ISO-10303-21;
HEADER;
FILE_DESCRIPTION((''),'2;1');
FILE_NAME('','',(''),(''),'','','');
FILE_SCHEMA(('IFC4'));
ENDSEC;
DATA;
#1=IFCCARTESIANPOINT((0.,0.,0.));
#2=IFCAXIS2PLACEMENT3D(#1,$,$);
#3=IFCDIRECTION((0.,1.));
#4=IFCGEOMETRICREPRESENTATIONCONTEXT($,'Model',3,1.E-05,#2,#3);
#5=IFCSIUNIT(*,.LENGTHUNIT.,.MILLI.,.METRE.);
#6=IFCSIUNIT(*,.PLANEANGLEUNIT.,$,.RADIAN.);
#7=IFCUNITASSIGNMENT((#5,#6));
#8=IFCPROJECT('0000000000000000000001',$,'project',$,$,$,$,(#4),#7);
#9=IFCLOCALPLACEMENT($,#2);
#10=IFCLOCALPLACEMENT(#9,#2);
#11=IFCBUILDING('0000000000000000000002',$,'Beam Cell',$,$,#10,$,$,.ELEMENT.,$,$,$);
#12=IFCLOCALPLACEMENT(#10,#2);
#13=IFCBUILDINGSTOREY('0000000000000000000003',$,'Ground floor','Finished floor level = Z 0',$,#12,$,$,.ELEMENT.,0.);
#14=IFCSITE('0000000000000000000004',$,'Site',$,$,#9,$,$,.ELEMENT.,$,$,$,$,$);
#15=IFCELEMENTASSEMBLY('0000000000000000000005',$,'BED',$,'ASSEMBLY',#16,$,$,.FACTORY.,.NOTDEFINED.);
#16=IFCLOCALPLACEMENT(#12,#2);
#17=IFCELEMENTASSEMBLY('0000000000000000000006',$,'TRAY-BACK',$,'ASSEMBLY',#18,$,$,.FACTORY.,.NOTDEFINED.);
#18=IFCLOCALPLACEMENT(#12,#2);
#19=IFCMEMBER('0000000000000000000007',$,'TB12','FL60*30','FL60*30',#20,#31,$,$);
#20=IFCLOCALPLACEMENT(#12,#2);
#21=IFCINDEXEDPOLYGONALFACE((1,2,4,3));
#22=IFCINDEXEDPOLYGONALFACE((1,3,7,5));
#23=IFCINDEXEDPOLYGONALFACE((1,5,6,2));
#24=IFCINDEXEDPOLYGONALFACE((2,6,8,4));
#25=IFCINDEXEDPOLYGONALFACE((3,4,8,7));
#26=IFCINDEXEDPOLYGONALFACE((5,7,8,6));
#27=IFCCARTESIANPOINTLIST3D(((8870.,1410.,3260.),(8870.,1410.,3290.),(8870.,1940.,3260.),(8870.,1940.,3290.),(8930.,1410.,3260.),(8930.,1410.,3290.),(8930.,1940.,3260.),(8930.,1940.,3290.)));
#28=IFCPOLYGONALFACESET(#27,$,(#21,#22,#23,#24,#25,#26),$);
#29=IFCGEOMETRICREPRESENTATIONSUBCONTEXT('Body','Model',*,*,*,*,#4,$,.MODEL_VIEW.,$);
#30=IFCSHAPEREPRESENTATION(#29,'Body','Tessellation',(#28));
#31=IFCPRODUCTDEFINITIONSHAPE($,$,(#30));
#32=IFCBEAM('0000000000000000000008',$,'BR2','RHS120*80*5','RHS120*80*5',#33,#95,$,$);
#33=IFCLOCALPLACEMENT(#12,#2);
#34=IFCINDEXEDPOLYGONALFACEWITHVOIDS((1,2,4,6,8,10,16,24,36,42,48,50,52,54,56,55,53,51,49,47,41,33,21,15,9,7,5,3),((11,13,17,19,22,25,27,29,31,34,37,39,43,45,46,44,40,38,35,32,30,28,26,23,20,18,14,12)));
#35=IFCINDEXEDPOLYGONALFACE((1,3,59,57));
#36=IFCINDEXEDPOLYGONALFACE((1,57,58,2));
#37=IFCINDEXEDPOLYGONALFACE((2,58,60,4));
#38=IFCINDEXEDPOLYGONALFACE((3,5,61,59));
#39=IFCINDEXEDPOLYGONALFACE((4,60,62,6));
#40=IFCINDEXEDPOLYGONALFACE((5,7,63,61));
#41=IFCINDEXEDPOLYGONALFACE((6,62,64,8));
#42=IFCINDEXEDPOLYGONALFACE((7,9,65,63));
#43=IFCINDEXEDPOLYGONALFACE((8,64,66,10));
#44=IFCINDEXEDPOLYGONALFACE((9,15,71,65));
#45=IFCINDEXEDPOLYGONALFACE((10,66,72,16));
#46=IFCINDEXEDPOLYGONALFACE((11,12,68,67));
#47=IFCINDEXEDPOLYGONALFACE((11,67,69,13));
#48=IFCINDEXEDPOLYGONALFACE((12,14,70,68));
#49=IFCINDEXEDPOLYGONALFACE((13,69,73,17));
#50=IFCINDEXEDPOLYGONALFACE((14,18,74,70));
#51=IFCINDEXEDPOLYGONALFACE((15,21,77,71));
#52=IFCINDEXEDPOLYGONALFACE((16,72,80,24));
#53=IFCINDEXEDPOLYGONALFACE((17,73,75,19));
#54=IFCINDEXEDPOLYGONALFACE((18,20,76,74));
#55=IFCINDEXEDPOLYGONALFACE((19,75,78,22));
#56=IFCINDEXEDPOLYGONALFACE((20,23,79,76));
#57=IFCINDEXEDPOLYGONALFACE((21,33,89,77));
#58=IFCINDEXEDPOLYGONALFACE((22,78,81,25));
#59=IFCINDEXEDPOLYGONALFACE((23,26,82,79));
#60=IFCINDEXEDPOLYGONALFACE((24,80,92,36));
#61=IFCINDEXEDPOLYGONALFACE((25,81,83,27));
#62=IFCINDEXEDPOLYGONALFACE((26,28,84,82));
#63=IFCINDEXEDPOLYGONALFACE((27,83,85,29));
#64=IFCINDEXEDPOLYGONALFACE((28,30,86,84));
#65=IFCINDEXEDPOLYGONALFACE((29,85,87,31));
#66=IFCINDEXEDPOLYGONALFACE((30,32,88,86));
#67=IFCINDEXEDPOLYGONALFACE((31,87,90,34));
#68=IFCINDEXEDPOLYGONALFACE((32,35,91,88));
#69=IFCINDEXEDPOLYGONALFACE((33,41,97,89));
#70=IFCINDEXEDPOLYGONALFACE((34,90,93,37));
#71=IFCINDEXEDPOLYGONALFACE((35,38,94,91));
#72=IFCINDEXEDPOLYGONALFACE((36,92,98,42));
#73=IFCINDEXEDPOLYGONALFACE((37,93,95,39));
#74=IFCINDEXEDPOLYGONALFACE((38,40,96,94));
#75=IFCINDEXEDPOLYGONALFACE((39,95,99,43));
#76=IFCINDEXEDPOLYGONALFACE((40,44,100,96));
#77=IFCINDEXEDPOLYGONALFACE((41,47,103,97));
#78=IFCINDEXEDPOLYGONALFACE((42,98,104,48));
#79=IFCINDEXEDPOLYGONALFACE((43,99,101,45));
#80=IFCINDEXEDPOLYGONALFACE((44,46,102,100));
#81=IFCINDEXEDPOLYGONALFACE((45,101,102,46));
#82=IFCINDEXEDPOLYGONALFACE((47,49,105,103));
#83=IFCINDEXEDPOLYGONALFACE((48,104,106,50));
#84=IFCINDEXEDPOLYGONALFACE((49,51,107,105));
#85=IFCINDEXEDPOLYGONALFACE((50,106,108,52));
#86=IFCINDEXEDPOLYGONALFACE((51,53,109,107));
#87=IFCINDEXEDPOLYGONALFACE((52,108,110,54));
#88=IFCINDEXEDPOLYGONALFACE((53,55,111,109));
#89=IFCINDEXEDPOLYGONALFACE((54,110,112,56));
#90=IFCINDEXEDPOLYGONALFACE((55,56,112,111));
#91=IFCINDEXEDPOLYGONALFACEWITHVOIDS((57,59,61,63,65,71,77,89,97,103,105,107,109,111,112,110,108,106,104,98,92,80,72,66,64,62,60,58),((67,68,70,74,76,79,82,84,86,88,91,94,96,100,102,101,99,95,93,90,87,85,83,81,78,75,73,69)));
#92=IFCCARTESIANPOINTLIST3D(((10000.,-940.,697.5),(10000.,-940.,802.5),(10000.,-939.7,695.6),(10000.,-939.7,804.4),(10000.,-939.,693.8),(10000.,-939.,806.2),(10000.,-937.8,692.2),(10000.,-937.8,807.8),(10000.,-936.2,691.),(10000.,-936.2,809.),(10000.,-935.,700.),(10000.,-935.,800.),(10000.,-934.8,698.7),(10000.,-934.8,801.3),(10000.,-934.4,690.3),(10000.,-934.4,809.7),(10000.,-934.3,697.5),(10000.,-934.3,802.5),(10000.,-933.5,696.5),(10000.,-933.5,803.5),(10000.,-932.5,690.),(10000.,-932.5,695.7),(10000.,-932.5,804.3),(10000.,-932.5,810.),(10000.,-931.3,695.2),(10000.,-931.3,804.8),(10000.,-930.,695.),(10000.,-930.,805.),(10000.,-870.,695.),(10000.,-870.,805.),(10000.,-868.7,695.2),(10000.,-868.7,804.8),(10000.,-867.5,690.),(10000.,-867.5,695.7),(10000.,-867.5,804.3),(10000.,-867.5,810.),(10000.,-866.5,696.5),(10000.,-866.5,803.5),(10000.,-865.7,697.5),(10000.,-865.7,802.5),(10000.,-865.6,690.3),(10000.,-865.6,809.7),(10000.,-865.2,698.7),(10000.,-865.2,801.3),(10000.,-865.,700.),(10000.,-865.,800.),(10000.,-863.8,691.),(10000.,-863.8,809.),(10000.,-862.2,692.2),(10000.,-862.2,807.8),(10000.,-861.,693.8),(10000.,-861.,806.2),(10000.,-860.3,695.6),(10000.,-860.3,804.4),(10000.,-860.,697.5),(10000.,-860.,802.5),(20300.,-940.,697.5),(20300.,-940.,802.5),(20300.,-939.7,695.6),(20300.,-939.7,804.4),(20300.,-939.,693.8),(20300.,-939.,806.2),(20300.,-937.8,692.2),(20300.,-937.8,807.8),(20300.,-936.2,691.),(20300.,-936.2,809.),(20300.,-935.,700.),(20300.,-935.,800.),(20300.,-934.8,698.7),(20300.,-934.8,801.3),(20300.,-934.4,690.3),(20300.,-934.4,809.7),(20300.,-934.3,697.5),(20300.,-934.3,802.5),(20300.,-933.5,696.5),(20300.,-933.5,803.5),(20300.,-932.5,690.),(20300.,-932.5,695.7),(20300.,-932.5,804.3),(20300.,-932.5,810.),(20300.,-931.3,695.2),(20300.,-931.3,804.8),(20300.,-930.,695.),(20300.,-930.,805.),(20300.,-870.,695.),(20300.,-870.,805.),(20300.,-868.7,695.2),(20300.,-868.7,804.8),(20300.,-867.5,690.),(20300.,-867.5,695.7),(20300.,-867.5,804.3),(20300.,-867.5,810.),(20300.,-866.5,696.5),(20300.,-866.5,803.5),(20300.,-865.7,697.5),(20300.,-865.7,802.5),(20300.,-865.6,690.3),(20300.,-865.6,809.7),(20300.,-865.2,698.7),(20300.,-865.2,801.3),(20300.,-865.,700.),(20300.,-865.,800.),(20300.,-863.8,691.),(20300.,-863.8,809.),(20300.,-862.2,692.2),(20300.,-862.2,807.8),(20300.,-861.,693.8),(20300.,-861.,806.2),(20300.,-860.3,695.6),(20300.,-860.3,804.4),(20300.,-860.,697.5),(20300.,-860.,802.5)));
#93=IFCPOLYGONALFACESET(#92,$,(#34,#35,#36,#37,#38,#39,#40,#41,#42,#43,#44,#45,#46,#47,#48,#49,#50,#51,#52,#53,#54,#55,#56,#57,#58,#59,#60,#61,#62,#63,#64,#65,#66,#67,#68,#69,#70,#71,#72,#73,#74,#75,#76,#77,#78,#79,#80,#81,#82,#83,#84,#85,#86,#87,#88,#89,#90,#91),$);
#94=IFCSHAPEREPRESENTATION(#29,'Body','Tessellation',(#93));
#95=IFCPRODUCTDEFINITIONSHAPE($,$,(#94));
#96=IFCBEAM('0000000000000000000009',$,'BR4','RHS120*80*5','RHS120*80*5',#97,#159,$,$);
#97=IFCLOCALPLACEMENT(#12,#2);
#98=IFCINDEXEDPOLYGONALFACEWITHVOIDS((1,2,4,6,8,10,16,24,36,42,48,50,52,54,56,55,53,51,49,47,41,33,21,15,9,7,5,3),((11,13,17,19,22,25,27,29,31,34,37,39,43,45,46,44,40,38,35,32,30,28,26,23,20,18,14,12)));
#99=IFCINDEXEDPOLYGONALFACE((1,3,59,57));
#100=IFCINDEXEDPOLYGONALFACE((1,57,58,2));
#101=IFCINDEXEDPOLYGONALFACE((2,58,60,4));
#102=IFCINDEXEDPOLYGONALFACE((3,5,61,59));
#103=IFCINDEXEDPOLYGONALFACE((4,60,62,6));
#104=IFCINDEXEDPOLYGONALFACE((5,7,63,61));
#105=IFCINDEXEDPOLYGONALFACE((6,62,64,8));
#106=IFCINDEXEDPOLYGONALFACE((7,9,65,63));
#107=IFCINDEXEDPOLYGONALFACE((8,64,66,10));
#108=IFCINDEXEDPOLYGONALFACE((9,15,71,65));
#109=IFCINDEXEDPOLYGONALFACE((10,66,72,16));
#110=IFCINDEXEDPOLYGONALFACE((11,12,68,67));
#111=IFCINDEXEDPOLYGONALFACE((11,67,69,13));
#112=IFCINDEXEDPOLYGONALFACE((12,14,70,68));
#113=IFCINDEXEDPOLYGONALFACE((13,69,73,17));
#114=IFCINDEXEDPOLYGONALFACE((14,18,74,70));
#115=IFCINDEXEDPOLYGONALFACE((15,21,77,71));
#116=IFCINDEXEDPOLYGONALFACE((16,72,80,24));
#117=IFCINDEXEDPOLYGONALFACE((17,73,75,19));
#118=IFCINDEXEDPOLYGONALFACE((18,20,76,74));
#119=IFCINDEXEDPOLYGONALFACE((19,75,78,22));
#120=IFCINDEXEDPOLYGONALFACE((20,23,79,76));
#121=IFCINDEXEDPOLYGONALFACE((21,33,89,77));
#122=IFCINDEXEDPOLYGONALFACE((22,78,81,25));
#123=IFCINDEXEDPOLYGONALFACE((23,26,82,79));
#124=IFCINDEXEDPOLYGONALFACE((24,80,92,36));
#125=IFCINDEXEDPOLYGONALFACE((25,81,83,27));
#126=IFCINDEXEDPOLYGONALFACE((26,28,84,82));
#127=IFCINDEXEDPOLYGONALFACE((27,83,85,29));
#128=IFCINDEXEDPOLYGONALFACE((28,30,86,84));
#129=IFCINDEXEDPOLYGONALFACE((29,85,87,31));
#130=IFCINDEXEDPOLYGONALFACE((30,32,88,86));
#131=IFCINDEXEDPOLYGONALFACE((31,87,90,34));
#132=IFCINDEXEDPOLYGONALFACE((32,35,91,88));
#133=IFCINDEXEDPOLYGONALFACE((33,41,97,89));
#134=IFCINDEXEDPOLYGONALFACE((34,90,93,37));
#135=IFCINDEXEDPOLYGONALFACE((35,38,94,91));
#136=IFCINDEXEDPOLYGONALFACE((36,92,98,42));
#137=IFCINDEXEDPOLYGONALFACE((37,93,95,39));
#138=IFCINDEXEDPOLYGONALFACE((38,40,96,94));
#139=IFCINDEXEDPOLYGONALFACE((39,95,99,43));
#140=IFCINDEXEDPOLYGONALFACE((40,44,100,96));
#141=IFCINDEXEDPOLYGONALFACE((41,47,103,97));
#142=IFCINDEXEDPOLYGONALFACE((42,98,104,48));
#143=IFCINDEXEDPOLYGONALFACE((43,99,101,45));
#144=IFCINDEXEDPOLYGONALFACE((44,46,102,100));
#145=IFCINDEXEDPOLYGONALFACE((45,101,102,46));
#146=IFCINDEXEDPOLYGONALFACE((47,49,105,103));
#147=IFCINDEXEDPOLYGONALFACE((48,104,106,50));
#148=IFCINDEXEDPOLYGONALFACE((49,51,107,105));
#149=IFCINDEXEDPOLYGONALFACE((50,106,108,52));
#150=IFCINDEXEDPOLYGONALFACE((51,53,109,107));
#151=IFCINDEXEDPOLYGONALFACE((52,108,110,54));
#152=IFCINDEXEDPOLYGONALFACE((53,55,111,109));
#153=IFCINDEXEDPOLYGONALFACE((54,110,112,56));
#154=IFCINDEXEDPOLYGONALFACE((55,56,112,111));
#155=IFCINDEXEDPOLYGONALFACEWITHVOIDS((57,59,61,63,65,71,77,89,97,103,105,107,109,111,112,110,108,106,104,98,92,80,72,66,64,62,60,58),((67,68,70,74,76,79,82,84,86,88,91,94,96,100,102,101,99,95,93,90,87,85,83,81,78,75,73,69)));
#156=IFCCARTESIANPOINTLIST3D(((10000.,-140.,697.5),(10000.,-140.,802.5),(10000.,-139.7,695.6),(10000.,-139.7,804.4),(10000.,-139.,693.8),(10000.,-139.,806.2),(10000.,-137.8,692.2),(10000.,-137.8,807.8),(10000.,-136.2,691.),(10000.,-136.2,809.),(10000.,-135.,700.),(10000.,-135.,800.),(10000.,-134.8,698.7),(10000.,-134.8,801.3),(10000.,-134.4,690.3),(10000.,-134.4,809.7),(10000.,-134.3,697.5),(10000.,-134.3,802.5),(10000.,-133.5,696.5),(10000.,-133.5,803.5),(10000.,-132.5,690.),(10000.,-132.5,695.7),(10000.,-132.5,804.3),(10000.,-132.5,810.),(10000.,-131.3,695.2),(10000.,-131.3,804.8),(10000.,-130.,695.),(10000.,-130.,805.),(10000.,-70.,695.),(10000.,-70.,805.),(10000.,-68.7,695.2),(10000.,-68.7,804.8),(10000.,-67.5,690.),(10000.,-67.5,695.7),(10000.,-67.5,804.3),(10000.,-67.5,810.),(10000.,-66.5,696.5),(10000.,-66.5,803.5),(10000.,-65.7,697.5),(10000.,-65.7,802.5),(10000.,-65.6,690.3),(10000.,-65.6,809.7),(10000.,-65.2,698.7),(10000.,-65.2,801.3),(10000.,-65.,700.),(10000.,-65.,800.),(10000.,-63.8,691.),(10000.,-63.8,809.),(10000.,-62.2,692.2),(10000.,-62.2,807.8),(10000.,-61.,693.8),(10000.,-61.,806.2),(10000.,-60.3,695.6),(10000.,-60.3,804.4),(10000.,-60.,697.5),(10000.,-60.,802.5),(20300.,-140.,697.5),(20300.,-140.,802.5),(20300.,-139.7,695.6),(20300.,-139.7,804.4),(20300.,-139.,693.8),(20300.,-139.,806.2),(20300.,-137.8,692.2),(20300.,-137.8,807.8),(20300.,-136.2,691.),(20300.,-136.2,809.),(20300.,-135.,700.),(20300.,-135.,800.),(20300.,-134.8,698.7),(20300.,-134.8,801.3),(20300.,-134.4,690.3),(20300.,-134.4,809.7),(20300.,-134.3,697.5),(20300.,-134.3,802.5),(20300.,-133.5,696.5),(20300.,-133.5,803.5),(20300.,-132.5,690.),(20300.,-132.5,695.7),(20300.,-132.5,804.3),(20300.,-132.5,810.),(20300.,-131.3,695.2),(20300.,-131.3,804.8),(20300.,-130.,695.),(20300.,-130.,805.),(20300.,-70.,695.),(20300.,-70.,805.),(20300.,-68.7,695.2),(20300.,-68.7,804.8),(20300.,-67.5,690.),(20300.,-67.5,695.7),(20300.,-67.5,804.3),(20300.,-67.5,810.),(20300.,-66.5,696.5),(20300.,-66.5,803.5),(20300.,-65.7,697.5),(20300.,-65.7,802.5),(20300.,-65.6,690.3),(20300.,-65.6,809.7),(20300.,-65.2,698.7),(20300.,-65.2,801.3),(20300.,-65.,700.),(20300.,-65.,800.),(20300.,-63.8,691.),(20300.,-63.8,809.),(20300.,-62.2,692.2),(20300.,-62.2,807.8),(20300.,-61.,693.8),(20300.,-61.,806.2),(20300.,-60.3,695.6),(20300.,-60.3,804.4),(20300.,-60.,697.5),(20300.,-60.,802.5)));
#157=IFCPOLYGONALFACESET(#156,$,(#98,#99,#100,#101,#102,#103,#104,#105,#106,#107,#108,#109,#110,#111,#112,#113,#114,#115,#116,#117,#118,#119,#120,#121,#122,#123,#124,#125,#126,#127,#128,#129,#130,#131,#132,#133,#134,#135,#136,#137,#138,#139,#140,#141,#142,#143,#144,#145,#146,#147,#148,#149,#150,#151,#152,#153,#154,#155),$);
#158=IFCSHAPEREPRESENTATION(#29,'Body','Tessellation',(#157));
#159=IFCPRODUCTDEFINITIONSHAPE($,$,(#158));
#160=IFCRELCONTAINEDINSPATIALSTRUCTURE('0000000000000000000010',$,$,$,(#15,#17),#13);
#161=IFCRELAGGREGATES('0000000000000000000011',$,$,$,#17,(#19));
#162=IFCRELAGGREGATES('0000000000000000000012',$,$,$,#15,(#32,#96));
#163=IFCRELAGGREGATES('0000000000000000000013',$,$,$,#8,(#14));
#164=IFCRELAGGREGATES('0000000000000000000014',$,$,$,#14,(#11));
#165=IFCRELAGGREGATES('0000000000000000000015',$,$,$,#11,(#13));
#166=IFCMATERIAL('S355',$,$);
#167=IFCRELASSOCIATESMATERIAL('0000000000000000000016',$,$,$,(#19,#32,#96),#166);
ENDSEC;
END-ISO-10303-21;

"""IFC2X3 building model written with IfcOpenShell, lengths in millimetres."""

from ifc_helpers import new_model, si_unit, direction, frame, origin, origin_2d, place, context, subcontext, project, spatial, rectangle, hollow_rectangle, extrude, material, element, aggregate, save


model = new_model("IFC2X3")

# Units and contexts
model_context = context("Model", 3, precision=1e-05, world=origin(), true_north=direction((0.0, 1.0)))
body_context = subcontext(model_context, "Body", "Model", "MODEL_VIEW")
ifc_project = project(units=[si_unit("LENGTHUNIT", "METRE", prefix="MILLI"), si_unit("PLANEANGLEUNIT", "RADIAN")], contexts=[model_context])

# Site, building, storey
site_placement = place(None, origin())
site = spatial("IfcSite", under=ifc_project, at=site_placement, Name="Site", CompositionType="ELEMENT")
building_placement = place(site_placement, origin())
building = spatial("IfcBuilding", under=site, at=building_placement, Name="Beam Cell", CompositionType="ELEMENT")
storey_placement = place(building_placement, origin())
storey = spatial("IfcBuildingStorey", under=building, at=storey_placement, Name="Ground floor", Description="Finished floor level = Z 0", CompositionType="ELEMENT", Elevation=0.0)

# Element assembly
ifc_material = material(Name="S355")
assembly_1_placement = place(storey_placement, origin())
assembly_1 = element("IfcElementAssembly", 1, at=assembly_1_placement, inside=storey, Name="BED", ObjectType="ASSEMBLY", AssemblyPlace="FACTORY", PredefinedType="NOTDEFINED")

# Element assembly, member
assembly_2_placement = place(storey_placement, origin())
assembly_2 = element("IfcElementAssembly", 2, at=assembly_2_placement, inside=storey, Name="TRAY-BACK", ObjectType="ASSEMBLY", AssemblyPlace="FACTORY", PredefinedType="NOTDEFINED")
member_1_placement = place(storey_placement, frame((8900.0, 1410.0, 3275.0), z_axis=(0.0, 1.0, 0.0), x_axis=(1.0, 0.0, 0.0)))
member_1 = element("IfcMember", 3, at=member_1_placement, material=ifc_material, Name="TB12", Description="FL60*30", ObjectType="FL60*30", context=body_context, shape_type="SweptSolid", body=[
    extrude(rectangle(XDim=60.0, YDim=30.0, at=origin_2d()), origin(), (0.0, 0.0, 1.0), 530.0),
])
aggregate(assembly_2, [member_1])

# Beams
beam_1_placement = place(storey_placement, frame((10000.0, -900.0, 750.0), z_axis=(1.0, 0.0, 0.0), x_axis=(0.0, 1.0, 0.0)))
beam_1 = element("IfcBeam", 4, at=beam_1_placement, material=ifc_material, Name="BR2", Description="RHS120*80*5", ObjectType="RHS120*80*5", context=body_context, shape_type="SweptSolid", body=[
    extrude(hollow_rectangle(XDim=80.0, YDim=120.0, WallThickness=5.0, InnerFilletRadius=5.0, OuterFilletRadius=7.5, at=origin_2d()), origin(), (0.0, 0.0, 1.0), 10300.0),
])
beam_2_placement = place(storey_placement, frame((10000.0, -100.0, 750.0), z_axis=(1.0, 0.0, 0.0), x_axis=(0.0, 1.0, 0.0)))
beam_2 = element("IfcBeam", 5, at=beam_2_placement, material=ifc_material, Name="BR4", Description="RHS120*80*5", ObjectType="RHS120*80*5", context=body_context, shape_type="SweptSolid", body=[
    extrude(hollow_rectangle(XDim=80.0, YDim=120.0, WallThickness=5.0, InnerFilletRadius=5.0, OuterFilletRadius=7.5, at=origin_2d()), origin(), (0.0, 0.0, 1.0), 10300.0),
])
aggregate(assembly_1, [beam_1, beam_2])

save(model, "model.ifc")
